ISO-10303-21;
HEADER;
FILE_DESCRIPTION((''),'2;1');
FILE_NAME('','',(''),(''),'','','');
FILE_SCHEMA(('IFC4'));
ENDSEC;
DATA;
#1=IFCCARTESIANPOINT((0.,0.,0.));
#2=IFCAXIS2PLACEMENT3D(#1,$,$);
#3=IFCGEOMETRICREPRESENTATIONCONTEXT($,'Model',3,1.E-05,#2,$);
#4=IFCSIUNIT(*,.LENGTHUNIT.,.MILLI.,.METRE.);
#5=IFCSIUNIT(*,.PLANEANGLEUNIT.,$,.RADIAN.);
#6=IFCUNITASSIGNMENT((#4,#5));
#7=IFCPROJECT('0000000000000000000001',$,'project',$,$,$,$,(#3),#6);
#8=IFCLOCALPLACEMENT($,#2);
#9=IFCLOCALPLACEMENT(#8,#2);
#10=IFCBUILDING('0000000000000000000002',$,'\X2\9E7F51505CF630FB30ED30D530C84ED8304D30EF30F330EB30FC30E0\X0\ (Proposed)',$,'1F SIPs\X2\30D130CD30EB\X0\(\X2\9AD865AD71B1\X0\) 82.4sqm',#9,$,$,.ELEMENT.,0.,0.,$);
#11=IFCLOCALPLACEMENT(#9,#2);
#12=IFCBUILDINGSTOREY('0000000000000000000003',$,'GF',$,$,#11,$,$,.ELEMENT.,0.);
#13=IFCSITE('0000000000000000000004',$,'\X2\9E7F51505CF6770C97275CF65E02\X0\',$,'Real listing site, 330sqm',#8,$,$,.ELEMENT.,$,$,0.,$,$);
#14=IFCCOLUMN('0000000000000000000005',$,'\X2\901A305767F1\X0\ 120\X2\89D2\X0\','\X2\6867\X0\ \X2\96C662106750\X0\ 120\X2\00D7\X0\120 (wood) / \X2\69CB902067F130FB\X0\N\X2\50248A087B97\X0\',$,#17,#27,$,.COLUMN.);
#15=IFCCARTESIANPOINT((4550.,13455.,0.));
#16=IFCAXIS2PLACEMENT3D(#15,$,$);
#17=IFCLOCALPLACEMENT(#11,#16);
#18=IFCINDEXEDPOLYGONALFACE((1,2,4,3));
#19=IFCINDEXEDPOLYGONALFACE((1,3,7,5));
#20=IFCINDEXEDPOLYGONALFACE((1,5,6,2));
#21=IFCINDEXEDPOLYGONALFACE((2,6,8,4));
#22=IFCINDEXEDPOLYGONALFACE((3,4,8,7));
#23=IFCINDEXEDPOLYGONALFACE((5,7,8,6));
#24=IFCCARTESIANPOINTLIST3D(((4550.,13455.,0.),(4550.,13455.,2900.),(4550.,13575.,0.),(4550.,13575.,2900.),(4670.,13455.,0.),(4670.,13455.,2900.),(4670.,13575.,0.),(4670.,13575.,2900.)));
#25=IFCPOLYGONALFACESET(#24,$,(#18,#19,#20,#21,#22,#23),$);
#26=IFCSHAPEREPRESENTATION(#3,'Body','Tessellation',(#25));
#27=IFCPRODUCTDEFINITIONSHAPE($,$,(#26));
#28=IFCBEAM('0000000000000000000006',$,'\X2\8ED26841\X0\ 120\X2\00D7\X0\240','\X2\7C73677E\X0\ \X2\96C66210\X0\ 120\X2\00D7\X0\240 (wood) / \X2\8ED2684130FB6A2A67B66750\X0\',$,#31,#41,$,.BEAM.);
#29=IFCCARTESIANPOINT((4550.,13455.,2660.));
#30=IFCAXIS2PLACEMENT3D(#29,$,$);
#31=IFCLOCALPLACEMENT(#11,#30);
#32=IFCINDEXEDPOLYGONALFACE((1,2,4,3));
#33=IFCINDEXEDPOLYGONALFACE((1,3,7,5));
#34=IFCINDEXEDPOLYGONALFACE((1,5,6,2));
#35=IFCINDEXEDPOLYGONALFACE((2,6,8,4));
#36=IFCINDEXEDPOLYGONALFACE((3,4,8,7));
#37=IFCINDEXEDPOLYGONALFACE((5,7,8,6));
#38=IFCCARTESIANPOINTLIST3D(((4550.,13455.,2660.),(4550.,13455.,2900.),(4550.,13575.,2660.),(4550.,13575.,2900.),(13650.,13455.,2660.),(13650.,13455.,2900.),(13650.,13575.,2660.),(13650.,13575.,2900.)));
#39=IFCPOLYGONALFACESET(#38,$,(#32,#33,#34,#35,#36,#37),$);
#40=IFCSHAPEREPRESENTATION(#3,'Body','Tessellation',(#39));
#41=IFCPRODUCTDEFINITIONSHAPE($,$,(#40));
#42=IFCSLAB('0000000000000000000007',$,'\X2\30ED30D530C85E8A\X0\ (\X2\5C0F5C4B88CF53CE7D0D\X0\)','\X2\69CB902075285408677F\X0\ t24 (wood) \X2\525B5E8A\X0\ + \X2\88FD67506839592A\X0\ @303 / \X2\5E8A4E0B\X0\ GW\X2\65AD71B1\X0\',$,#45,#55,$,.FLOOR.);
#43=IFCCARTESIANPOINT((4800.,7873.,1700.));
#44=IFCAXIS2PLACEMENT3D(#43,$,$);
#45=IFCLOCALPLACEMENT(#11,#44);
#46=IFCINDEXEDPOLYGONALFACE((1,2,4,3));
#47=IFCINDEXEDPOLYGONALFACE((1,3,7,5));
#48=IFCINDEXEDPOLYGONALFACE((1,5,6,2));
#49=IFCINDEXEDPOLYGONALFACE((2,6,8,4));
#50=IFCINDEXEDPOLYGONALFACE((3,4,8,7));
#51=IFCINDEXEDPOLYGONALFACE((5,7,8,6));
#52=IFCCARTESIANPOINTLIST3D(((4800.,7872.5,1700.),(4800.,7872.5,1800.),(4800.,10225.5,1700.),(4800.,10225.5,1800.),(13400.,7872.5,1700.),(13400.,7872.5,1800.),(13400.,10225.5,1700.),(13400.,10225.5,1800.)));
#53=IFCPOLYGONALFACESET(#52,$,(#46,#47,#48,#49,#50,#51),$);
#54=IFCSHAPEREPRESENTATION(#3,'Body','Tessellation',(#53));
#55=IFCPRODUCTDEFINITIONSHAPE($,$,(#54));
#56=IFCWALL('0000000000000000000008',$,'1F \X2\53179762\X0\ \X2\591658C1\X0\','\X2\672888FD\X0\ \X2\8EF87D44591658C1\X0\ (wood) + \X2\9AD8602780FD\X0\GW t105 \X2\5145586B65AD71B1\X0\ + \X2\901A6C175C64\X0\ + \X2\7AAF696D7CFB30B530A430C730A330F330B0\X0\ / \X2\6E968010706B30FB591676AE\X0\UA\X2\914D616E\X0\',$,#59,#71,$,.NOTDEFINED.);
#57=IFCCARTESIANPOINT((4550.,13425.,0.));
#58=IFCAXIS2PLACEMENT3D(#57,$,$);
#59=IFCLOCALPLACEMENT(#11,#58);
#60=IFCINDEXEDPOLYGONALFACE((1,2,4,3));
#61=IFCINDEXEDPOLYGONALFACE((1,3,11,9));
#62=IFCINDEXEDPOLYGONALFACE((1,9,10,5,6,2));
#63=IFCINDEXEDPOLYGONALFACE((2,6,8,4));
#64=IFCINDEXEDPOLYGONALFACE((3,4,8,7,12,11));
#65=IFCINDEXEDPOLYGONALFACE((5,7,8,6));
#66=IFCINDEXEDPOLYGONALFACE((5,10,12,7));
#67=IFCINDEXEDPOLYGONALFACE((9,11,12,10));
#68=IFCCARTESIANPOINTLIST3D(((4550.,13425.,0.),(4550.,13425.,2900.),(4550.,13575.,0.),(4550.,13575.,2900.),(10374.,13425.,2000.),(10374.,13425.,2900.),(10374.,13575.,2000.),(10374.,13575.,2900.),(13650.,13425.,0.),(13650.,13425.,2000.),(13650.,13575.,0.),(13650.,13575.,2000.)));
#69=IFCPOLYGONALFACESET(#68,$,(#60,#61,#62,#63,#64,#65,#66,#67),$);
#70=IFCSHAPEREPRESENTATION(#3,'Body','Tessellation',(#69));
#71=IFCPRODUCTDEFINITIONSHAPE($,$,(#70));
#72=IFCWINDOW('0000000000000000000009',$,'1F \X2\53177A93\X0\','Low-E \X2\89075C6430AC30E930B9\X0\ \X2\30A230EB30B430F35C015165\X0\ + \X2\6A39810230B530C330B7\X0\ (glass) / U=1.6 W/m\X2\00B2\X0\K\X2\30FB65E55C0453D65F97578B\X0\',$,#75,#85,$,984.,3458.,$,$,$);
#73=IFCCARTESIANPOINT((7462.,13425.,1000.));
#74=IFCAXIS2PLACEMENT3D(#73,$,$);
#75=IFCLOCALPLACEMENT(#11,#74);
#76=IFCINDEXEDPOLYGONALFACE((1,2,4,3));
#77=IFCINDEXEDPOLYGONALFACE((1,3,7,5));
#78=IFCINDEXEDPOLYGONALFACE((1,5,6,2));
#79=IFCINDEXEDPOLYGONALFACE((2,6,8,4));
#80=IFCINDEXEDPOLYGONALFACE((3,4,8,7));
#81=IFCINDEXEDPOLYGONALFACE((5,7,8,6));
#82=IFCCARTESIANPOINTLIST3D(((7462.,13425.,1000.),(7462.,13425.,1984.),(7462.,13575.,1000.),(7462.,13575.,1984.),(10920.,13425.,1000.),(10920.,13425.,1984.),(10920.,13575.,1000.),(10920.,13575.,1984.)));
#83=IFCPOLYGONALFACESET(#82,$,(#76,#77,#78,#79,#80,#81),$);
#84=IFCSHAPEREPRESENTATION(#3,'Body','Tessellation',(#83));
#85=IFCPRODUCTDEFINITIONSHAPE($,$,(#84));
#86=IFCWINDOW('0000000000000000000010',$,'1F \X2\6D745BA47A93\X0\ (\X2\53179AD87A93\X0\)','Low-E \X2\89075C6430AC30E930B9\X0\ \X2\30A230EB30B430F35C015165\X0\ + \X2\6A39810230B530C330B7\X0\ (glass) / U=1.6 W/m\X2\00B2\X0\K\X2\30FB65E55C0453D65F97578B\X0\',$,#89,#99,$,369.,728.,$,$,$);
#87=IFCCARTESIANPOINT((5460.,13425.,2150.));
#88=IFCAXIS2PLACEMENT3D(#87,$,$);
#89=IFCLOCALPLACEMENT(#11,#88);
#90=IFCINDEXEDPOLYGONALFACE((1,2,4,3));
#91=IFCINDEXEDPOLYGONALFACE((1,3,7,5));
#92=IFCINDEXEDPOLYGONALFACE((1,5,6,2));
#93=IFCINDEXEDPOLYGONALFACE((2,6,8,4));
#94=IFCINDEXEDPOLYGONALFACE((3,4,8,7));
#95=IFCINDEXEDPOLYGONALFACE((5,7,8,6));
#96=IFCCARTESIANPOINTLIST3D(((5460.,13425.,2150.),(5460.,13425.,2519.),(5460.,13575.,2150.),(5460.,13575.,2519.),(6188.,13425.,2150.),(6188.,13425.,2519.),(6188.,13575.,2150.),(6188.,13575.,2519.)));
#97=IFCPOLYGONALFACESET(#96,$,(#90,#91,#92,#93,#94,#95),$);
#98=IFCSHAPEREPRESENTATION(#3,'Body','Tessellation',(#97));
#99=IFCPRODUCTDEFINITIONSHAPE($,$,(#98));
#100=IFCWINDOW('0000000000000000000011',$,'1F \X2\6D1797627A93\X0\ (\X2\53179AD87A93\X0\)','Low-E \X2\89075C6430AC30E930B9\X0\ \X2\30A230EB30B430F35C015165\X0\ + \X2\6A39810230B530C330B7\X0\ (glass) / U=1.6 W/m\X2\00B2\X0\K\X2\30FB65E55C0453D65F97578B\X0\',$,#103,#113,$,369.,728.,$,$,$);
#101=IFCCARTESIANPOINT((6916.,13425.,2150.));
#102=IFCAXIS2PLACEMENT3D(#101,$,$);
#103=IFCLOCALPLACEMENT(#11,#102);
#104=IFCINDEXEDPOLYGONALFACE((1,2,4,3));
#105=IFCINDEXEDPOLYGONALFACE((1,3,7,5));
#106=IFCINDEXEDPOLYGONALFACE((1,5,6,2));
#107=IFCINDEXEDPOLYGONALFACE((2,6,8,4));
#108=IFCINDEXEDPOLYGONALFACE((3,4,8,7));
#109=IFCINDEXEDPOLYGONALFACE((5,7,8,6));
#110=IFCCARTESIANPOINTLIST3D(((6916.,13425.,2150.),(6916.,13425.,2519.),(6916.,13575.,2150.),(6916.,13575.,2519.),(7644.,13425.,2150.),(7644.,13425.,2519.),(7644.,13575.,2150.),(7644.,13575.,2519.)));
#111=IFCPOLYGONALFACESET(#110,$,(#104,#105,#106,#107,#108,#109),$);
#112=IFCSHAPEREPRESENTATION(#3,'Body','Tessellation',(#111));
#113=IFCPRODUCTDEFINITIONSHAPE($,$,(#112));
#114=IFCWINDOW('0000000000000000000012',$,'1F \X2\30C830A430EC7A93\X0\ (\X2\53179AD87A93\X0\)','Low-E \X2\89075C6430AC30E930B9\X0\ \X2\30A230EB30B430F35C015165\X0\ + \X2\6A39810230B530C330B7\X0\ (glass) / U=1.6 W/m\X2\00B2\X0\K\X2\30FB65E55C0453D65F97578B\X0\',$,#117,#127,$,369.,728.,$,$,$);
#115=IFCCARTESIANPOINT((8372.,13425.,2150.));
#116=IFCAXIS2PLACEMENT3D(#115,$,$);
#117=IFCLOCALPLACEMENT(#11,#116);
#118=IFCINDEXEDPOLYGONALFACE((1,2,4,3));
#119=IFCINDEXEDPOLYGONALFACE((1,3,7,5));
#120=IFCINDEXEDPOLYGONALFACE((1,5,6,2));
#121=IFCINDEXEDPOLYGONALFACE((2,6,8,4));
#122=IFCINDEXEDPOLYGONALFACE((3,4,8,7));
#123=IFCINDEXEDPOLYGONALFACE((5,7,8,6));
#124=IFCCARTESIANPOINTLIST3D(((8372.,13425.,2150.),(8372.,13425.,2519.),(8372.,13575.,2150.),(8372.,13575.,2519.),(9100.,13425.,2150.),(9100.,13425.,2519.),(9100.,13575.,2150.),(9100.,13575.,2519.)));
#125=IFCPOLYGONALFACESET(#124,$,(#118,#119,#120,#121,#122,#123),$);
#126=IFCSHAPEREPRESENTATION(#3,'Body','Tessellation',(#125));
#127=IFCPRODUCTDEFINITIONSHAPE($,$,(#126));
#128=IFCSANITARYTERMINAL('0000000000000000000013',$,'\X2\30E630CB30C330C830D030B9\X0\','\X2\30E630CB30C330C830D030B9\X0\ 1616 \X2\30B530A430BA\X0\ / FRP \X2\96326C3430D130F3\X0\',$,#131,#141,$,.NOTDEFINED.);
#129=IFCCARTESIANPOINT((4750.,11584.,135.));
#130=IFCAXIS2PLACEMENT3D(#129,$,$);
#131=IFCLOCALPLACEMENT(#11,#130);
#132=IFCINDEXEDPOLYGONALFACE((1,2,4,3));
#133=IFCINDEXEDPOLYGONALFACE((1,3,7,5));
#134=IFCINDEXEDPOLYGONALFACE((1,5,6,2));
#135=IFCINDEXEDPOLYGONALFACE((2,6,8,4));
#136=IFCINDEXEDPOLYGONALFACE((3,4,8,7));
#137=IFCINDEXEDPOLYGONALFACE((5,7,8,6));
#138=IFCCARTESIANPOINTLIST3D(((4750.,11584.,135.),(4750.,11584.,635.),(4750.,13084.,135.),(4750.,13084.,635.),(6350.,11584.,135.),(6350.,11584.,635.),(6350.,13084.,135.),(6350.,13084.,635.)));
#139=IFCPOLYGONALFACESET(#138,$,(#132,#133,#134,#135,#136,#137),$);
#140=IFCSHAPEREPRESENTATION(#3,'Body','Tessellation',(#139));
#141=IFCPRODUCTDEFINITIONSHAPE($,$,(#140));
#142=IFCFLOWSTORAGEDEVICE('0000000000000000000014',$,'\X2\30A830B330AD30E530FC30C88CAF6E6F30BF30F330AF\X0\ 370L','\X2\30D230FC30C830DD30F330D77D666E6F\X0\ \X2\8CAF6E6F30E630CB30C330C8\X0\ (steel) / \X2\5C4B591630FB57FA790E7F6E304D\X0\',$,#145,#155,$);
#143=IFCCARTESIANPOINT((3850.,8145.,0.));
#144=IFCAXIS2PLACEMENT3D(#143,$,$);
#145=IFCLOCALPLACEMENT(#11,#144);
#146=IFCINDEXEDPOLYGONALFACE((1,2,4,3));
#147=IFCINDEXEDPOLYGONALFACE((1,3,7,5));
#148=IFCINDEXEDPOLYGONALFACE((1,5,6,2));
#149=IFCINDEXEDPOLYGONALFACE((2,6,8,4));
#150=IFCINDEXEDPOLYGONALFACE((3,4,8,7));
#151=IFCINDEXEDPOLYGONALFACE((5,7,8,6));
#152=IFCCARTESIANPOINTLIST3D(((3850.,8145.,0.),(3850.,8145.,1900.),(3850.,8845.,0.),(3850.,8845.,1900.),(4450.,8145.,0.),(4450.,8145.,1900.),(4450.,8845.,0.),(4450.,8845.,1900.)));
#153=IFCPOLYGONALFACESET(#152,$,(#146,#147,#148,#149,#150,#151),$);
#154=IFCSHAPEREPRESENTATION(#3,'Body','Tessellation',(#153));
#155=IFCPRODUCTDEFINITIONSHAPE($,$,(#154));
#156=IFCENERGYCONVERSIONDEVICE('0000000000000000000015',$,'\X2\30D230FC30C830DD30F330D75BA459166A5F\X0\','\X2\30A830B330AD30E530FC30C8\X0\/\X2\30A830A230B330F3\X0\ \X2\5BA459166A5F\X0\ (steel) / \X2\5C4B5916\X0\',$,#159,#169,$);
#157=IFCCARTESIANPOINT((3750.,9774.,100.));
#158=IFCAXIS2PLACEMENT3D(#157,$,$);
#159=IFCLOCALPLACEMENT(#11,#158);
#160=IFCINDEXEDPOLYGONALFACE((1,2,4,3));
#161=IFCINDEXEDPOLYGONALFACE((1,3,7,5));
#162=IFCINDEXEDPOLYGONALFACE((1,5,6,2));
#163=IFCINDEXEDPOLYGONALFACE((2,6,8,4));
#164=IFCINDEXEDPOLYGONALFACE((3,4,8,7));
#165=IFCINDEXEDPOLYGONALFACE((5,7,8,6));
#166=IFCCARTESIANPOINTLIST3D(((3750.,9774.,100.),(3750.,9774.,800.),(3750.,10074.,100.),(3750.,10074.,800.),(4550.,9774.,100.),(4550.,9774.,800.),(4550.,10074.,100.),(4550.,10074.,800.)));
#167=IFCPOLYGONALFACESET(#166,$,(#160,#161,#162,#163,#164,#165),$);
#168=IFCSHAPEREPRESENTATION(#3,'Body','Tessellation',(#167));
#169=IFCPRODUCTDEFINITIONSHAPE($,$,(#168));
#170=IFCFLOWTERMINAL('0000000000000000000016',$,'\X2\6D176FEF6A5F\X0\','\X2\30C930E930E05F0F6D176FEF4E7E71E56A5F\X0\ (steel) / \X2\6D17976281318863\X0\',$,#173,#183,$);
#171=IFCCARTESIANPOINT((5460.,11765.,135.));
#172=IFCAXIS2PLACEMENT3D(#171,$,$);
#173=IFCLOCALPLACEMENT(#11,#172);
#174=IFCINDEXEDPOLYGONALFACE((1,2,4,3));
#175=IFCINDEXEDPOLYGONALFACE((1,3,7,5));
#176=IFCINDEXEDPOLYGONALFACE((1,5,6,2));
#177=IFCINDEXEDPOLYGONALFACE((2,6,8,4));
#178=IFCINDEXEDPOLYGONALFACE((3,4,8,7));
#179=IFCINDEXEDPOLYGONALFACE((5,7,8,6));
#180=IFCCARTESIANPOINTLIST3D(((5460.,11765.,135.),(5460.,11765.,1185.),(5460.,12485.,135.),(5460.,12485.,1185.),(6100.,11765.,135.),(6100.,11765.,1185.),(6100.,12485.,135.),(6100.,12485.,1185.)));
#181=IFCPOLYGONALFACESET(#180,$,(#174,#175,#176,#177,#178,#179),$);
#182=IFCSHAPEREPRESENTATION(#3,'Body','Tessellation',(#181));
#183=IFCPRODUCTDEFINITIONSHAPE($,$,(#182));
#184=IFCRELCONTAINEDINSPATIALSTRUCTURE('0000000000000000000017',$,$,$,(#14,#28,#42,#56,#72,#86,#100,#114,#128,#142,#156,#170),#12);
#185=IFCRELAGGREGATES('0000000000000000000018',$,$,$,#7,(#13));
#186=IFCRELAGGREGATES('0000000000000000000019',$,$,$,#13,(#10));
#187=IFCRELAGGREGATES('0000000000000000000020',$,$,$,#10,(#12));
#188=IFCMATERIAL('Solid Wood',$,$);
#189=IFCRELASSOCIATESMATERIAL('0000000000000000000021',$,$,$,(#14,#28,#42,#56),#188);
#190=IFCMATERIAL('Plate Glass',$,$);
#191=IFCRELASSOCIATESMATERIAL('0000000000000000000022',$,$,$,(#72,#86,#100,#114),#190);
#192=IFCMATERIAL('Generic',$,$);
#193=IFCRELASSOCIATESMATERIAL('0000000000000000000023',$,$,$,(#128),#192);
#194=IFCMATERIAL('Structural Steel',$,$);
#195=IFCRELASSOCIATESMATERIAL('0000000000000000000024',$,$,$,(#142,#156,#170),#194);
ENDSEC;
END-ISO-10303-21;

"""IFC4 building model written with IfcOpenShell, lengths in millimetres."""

from ifc_helpers import new_model, si_unit, frame, frame_2d, origin, place, context, project, spatial, rectangle, extrude, material, element, fill, save


model = new_model("IFC4")

# Units and contexts
model_context = context("Model", 3, precision=1e-05, world=origin())
ifc_project = project(units=[si_unit("LENGTHUNIT", "METRE", prefix="MILLI"), si_unit("PLANEANGLEUNIT", "RADIAN")], contexts=[model_context])

# Site, building, storey
site_placement = place(None, origin())
site = spatial("IfcSite", under=ifc_project, at=site_placement, Name="鹿児島県霧島市", ObjectType="Real listing site, 330sqm", CompositionType="ELEMENT", RefElevation=0.0)
building_placement = place(site_placement, origin())
building = spatial("IfcBuilding", under=site, at=building_placement, Name="鹿児島・ロフト付きワンルーム (Proposed)", ObjectType="1F SIPsパネル(高断熱) 82.4sqm", CompositionType="ELEMENT", ElevationOfRefHeight=0.0, ElevationOfTerrain=0.0)
storey_placement = place(building_placement, origin())
storey = spatial("IfcBuildingStorey", under=building, at=storey_placement, Name="GF", CompositionType="ELEMENT", Elevation=0.0)

# Column
ifc_material_1 = material(Name="Solid Wood")
column_1_placement = place(storey_placement, frame((4550.0, 13455.0, 0.0)))
element("IfcColumn", 1, at=column_1_placement, inside=storey, material=ifc_material_1, Name="通し柱 120角", Description="桧 集成材 120×120 (wood) / 構造柱・N値計算", PredefinedType="COLUMN", context=model_context, shape_type="SweptSolid", body=[
    extrude(rectangle(XDim=120.0, YDim=120.0, at=frame_2d((60.0, 60.0))), frame((4550.0, 13455.0, 0.0)), (0.0, 0.0, 1.0), 2900.0),
])

# Beam
beam_1_placement = place(storey_placement, frame((4550.0, 13455.0, 2660.0)))
element("IfcBeam", 2, at=beam_1_placement, inside=storey, material=ifc_material_1, Name="軒桁 120×240", Description="米松 集成 120×240 (wood) / 軒桁・横架材", PredefinedType="BEAM", context=model_context, shape_type="SweptSolid", body=[
    extrude(rectangle(XDim=9100.0, YDim=120.0, at=frame_2d((4550.0, 60.0))), frame((4550.0, 13455.0, 2660.0)), (0.0, 0.0, 1.0), 240.0),
])

# Slab
slab_placement = place(storey_placement, frame((4800.0, 7873.0, 1700.0)))
element("IfcSlab", 3, at=slab_placement, inside=storey, material=ifc_material_1, Name="ロフト床 (小屋裏収納)", Description="構造用合板 t24 (wood) 剛床 + 製材根太 @303 / 床下 GW断熱", PredefinedType="FLOOR", context=model_context, shape_type="SweptSolid", body=[
    extrude(rectangle(XDim=8600.0, YDim=2353.0, at=frame_2d((4300.0, 1176.0))), frame((4800.0, 7873.0, 1700.0)), (0.0, 0.0, 1.0), 100.0),
])

# Wall, openings, windows
wall_1_placement = place(storey_placement, frame((4550.0, 13425.0, 0.0)))
wall_1 = element("IfcWall", 4, at=wall_1_placement, inside=storey, material=ifc_material_1, Name="1F 北面 外壁", Description="木製 軸組外壁 (wood) + 高性能GW t105 充填断熱 + 通気層 + 窯業系サイディング / 準耐火・外皮UA配慮", PredefinedType="NOTDEFINED", context=model_context, shape_type="SweptSolid", body=[
    extrude(rectangle(XDim=9100.0, YDim=150.0, at=frame_2d((4550.0, 75.0))), frame((4550.0, 13425.0, 0.0)), (0.0, 0.0, 1.0), 2900.0),
])
opening_1_placement = place(storey_placement, frame((7462.0, 13425.0, 1000.0)))
opening_1 = element("IfcOpeningElement", 5, at=opening_1_placement, cuts=wall_1, PredefinedType="NOTDEFINED", context=model_context, shape_type="SweptSolid", body=[
    extrude(rectangle(XDim=3458.0, YDim=150.0, at=frame_2d((1729.0, 75.0))), frame((7462.0, 13425.0, 1000.0)), (0.0, 0.0, 1.0), 984.0),
])
opening_2_placement = place(storey_placement, frame((5460.0, 13425.0, 2150.0)))
opening_2 = element("IfcOpeningElement", 6, at=opening_2_placement, cuts=wall_1, PredefinedType="NOTDEFINED", context=model_context, shape_type="SweptSolid", body=[
    extrude(rectangle(XDim=728.0, YDim=150.0, at=frame_2d((364.0, 75.0))), frame((5460.0, 13425.0, 2150.0)), (0.0, 0.0, 1.0), 369.0),
])
opening_3_placement = place(storey_placement, frame((6916.0, 13425.0, 2150.0)))
opening_3 = element("IfcOpeningElement", 7, at=opening_3_placement, cuts=wall_1, PredefinedType="NOTDEFINED", context=model_context, shape_type="SweptSolid", body=[
    extrude(rectangle(XDim=728.0, YDim=150.0, at=frame_2d((364.0, 75.0))), frame((6916.0, 13425.0, 2150.0)), (0.0, 0.0, 1.0), 369.0),
])
opening_4_placement = place(storey_placement, frame((8372.0, 13425.0, 2150.0)))
opening_4 = element("IfcOpeningElement", 8, at=opening_4_placement, cuts=wall_1, PredefinedType="NOTDEFINED", context=model_context, shape_type="SweptSolid", body=[
    extrude(rectangle(XDim=728.0, YDim=150.0, at=frame_2d((364.0, 75.0))), frame((8372.0, 13425.0, 2150.0)), (0.0, 0.0, 1.0), 369.0),
])
ifc_material_2 = material(Name="Plate Glass")
window_1_placement = place(storey_placement, frame((7462.0, 13425.0, 1000.0)))
window_1 = element("IfcWindow", 9, at=window_1_placement, inside=storey, material=ifc_material_2, Name="1F 北窓", Description="Low-E 複層ガラス アルゴン封入 + 樹脂サッシ (glass) / U=1.6 W/m²K・日射取得型", OverallHeight=984.0, OverallWidth=3458.0, context=model_context, shape_type="SweptSolid", body=[
    extrude(rectangle(XDim=3458.0, YDim=150.0, at=frame_2d((1729.0, 75.0))), frame((7462.0, 13425.0, 1000.0)), (0.0, 0.0, 1.0), 984.0),
])
fill(opening_1, window_1)
window_2_placement = place(storey_placement, frame((5460.0, 13425.0, 2150.0)))
window_2 = element("IfcWindow", 10, at=window_2_placement, inside=storey, material=ifc_material_2, Name="1F 浴室窓 (北高窓)", Description="Low-E 複層ガラス アルゴン封入 + 樹脂サッシ (glass) / U=1.6 W/m²K・日射取得型", OverallHeight=369.0, OverallWidth=728.0, context=model_context, shape_type="SweptSolid", body=[
    extrude(rectangle(XDim=728.0, YDim=150.0, at=frame_2d((364.0, 75.0))), frame((5460.0, 13425.0, 2150.0)), (0.0, 0.0, 1.0), 369.0),
])
fill(opening_2, window_2)
window_3_placement = place(storey_placement, frame((6916.0, 13425.0, 2150.0)))
window_3 = element("IfcWindow", 11, at=window_3_placement, inside=storey, material=ifc_material_2, Name="1F 洗面窓 (北高窓)", Description="Low-E 複層ガラス アルゴン封入 + 樹脂サッシ (glass) / U=1.6 W/m²K・日射取得型", OverallHeight=369.0, OverallWidth=728.0, context=model_context, shape_type="SweptSolid", body=[
    extrude(rectangle(XDim=728.0, YDim=150.0, at=frame_2d((364.0, 75.0))), frame((6916.0, 13425.0, 2150.0)), (0.0, 0.0, 1.0), 369.0),
])
fill(opening_3, window_3)
window_4_placement = place(storey_placement, frame((8372.0, 13425.0, 2150.0)))
window_4 = element("IfcWindow", 12, at=window_4_placement, inside=storey, material=ifc_material_2, Name="1F トイレ窓 (北高窓)", Description="Low-E 複層ガラス アルゴン封入 + 樹脂サッシ (glass) / U=1.6 W/m²K・日射取得型", OverallHeight=369.0, OverallWidth=728.0, context=model_context, shape_type="SweptSolid", body=[
    extrude(rectangle(XDim=728.0, YDim=150.0, at=frame_2d((364.0, 75.0))), frame((8372.0, 13425.0, 2150.0)), (0.0, 0.0, 1.0), 369.0),
])
fill(opening_4, window_4)

# Sanitary terminal
ifc_material_3 = material(Name="Generic")
sanitary_terminal_placement = place(storey_placement, frame((4750.0, 11584.0, 135.0)))
element("IfcSanitaryTerminal", 13, at=sanitary_terminal_placement, inside=storey, material=ifc_material_3, Name="ユニットバス", Description="ユニットバス 1616 サイズ / FRP 防水パン", PredefinedType="NOTDEFINED", context=model_context, shape_type="SweptSolid", body=[
    extrude(rectangle(XDim=1600.0, YDim=1500.0, at=frame_2d((800.0, 750.0))), frame((4750.0, 11584.0, 135.0)), (0.0, 0.0, 1.0), 500.0),
])

# Flow storage device
ifc_material_4 = material(Name="Structural Steel")
flow_storage_device_placement = place(storey_placement, frame((3850.0, 8145.0, 0.0)))
element("IfcFlowStorageDevice", 14, at=flow_storage_device_placement, inside=storey, material=ifc_material_4, Name="エコキュート貯湯タンク 370L", Description="ヒートポンプ給湯 貯湯ユニット (steel) / 屋外・基礎置き", context=model_context, shape_type="SweptSolid", body=[
    extrude(rectangle(XDim=600.0, YDim=700.0, at=frame_2d((300.0, 350.0))), frame((3850.0, 8145.0, 0.0)), (0.0, 0.0, 1.0), 1900.0),
])

# Energy conversion device
energy_conversion_device_placement = place(storey_placement, frame((3750.0, 9774.0, 100.0)))
element("IfcEnergyConversionDevice", 15, at=energy_conversion_device_placement, inside=storey, material=ifc_material_4, Name="ヒートポンプ室外機", Description="エコキュート/エアコン 室外機 (steel) / 屋外", context=model_context, shape_type="SweptSolid", body=[
    extrude(rectangle(XDim=800.0, YDim=300.0, at=frame_2d((400.0, 150.0))), frame((3750.0, 9774.0, 100.0)), (0.0, 0.0, 1.0), 700.0),
])

# Flow terminal
flow_terminal_placement = place(storey_placement, frame((5460.0, 11765.0, 135.0)))
element("IfcFlowTerminal", 16, at=flow_terminal_placement, inside=storey, material=ifc_material_4, Name="洗濯機", Description="ドラム式洗濯乾燥機 (steel) / 洗面脱衣", context=model_context, shape_type="SweptSolid", body=[
    extrude(rectangle(XDim=640.0, YDim=720.0, at=frame_2d((320.0, 360.0))), frame((5460.0, 11765.0, 135.0)), (0.0, 0.0, 1.0), 1050.0),
])

save(model, "model.ifc")
